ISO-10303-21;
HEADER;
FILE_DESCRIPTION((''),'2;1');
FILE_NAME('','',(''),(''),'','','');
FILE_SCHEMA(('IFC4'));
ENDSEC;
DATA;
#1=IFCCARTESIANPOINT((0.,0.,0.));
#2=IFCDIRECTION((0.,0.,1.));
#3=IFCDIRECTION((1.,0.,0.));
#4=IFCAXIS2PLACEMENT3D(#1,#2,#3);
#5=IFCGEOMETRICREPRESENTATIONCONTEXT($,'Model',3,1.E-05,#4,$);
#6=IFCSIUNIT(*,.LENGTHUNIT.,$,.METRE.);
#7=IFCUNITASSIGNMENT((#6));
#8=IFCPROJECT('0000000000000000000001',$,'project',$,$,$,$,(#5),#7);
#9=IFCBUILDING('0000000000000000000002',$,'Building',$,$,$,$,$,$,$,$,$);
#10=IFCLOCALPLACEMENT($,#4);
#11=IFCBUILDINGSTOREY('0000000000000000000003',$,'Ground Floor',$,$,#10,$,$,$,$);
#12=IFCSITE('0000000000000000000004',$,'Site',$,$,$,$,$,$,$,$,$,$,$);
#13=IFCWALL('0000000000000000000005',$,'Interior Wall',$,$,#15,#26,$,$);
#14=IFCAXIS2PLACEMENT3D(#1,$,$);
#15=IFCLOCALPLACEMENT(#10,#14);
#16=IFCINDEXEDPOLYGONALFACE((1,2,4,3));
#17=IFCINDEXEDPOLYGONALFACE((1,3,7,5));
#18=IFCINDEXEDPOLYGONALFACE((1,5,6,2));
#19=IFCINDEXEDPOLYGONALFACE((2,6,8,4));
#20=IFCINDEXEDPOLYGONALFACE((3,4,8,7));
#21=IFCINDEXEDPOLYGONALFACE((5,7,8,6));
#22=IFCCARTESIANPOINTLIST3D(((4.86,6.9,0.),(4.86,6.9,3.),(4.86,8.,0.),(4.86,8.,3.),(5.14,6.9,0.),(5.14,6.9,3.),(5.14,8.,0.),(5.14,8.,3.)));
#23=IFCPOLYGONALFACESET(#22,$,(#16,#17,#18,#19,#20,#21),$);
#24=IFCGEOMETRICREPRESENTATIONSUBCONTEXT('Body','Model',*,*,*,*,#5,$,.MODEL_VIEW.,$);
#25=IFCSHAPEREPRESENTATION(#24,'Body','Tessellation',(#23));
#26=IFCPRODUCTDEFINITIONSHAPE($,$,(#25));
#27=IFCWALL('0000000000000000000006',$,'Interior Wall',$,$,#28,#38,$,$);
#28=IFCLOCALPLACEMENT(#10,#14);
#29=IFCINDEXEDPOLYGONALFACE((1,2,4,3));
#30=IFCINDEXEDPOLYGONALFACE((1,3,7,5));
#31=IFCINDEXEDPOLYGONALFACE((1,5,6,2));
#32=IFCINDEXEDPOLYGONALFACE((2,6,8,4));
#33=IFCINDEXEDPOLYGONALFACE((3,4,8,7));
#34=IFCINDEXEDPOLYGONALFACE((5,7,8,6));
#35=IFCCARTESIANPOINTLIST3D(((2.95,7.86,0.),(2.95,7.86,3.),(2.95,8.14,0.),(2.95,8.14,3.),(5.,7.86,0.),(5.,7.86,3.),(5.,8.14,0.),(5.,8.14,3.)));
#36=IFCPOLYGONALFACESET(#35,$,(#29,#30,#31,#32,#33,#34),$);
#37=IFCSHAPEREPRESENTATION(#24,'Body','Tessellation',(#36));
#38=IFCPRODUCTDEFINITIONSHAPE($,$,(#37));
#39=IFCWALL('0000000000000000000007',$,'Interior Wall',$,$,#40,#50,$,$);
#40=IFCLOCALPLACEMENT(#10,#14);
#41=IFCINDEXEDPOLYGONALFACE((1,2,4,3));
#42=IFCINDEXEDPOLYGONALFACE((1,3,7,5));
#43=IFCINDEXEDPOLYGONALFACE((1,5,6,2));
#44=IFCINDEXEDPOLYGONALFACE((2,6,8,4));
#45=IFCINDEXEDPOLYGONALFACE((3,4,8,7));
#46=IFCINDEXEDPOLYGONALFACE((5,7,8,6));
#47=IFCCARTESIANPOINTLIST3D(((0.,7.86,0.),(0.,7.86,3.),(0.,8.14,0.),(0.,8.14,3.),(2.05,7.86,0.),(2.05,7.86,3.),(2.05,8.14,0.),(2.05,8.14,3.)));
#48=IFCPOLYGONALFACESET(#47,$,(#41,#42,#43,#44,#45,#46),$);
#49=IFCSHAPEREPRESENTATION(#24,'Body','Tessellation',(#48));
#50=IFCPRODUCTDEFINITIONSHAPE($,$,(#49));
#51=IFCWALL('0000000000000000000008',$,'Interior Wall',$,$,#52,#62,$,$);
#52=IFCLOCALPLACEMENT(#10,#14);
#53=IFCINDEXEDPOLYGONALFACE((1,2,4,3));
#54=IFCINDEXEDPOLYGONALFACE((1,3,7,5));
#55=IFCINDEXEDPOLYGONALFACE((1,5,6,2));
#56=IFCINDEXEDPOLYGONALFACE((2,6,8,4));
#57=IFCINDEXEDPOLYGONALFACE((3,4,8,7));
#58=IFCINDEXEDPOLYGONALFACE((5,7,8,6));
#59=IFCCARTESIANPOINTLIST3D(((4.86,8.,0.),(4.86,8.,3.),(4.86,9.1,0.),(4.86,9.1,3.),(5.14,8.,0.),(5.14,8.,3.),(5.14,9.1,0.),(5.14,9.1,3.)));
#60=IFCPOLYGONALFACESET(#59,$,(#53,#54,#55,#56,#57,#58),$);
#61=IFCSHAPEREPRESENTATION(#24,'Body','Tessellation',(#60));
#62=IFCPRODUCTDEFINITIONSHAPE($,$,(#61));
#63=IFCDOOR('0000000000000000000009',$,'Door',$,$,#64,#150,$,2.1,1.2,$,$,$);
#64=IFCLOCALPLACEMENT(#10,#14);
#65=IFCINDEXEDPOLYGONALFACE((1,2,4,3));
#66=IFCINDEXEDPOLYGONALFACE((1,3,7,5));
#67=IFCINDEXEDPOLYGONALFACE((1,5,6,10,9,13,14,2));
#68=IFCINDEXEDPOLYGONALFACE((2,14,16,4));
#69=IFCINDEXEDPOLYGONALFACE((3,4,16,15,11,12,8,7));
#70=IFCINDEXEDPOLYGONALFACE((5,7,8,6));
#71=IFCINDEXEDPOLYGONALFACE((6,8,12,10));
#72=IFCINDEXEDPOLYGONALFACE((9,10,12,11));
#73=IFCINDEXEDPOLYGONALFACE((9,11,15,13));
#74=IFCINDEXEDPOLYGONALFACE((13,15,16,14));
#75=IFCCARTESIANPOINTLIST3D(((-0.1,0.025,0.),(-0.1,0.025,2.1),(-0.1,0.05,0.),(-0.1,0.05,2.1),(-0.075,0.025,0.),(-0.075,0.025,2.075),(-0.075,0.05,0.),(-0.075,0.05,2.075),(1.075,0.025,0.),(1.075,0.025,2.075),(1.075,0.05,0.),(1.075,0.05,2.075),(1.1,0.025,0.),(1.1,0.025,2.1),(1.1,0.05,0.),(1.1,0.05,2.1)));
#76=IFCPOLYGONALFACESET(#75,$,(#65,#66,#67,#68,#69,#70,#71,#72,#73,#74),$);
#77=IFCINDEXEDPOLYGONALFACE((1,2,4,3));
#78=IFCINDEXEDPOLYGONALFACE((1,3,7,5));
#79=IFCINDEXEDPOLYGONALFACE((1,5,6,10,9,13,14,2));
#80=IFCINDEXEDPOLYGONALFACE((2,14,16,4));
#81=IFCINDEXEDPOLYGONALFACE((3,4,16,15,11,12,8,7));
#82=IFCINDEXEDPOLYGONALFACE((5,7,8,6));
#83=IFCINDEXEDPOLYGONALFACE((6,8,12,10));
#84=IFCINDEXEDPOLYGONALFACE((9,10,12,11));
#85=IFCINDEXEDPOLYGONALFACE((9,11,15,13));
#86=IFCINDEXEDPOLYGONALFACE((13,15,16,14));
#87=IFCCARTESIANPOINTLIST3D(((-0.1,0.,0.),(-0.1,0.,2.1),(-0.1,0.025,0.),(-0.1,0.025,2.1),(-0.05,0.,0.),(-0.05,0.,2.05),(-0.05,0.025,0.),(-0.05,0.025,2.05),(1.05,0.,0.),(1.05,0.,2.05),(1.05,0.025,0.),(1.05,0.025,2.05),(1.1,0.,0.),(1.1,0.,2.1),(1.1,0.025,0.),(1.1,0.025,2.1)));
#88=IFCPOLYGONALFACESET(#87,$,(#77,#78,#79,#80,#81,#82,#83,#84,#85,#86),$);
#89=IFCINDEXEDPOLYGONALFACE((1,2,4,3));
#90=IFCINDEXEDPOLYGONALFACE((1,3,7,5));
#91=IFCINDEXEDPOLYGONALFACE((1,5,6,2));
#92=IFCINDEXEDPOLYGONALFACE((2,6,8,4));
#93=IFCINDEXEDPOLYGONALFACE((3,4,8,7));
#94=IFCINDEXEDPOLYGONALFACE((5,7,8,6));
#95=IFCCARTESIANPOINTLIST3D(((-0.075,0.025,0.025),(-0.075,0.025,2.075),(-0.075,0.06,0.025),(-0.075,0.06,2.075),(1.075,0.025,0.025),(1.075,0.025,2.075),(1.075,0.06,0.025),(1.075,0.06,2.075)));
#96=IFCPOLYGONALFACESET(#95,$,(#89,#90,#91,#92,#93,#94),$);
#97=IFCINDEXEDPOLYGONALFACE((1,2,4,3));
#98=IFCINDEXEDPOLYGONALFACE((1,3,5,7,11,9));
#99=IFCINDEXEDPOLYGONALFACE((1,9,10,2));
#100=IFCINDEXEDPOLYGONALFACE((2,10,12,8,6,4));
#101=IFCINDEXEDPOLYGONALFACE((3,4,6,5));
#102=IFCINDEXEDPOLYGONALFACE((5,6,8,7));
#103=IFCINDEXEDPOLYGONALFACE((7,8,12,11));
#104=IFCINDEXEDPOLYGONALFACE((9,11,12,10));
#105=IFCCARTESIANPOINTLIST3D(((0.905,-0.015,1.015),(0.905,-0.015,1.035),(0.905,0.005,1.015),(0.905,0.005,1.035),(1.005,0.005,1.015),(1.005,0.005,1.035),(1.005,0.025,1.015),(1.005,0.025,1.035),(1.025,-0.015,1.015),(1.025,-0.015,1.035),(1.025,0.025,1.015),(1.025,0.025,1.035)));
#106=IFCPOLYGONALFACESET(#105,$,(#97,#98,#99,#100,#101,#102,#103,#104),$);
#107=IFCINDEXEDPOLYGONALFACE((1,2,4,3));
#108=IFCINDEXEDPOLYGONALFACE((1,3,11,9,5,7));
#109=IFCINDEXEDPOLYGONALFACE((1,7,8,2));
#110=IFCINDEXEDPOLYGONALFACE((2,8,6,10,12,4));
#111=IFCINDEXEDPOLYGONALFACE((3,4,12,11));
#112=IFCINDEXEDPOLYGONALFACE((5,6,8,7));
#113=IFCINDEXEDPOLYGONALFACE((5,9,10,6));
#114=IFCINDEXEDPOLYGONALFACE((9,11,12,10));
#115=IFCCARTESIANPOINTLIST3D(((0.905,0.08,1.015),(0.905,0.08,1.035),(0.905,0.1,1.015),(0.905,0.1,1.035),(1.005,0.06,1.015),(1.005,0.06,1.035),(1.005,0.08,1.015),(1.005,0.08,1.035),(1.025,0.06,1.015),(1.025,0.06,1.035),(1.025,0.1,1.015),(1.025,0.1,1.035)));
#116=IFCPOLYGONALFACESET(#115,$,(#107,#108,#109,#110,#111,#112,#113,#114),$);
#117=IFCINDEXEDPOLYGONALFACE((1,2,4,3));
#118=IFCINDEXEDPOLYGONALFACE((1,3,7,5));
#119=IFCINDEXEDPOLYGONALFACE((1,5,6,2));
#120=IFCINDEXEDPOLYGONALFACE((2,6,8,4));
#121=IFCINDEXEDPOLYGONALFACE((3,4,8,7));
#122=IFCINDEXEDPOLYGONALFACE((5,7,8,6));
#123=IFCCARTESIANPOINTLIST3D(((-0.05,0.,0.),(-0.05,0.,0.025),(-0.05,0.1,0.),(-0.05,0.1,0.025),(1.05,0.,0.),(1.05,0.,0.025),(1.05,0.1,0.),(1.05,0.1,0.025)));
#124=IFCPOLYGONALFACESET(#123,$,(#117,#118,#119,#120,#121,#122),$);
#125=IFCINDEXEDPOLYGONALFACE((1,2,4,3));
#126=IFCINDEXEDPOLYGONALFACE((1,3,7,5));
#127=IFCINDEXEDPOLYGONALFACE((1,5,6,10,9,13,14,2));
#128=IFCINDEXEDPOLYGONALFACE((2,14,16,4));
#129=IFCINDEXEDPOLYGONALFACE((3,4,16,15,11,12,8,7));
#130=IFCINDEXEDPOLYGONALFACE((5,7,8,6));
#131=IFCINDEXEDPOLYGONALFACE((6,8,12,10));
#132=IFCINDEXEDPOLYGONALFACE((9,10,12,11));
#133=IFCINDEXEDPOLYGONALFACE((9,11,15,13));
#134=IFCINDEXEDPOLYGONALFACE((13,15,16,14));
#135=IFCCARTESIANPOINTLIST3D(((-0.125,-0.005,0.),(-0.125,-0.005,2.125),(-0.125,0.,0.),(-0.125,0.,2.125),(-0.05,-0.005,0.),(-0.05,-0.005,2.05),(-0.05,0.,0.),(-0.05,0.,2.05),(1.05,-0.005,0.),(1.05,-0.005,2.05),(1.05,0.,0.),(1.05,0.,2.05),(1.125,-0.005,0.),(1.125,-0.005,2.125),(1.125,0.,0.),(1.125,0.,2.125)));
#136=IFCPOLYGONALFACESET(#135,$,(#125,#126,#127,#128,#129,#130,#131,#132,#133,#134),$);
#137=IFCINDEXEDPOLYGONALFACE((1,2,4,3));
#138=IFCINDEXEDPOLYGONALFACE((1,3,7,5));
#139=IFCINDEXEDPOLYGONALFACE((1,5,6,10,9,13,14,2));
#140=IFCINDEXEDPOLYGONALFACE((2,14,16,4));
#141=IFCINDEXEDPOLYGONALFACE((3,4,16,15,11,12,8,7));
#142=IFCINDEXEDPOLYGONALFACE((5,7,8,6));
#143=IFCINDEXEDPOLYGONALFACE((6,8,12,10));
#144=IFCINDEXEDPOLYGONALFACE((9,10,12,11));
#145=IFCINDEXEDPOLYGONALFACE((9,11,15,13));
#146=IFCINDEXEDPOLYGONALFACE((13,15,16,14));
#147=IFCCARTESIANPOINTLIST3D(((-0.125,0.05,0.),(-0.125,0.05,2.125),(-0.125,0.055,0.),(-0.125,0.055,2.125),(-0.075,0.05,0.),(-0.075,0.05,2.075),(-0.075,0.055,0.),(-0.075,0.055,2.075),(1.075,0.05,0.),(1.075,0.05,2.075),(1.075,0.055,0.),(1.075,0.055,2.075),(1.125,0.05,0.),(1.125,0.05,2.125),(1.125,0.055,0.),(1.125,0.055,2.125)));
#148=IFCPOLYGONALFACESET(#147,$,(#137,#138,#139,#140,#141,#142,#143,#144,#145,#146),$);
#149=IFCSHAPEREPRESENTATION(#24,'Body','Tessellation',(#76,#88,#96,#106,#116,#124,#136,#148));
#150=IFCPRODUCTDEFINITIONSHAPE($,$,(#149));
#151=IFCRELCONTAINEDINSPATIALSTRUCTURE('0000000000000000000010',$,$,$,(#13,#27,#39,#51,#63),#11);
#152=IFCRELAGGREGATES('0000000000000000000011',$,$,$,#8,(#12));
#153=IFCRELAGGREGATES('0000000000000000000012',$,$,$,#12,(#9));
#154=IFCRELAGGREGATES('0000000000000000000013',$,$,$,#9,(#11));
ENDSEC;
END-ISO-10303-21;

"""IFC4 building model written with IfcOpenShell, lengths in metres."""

from ifc_helpers import new_model, si_unit, frame, origin_with_axes, place, context, subcontext, project, spatial, line, indexed_curve, outline, extrude, element, save


model = new_model("IFC4")

# Units and contexts
model_context = context("Model", 3, precision=1e-05, world=origin_with_axes())
body_context = subcontext(model_context, "Body", "Model", "MODEL_VIEW")
ifc_project = project(units=[si_unit("LENGTHUNIT", "METRE")], contexts=[model_context])

# Site, building, storey
site = spatial("IfcSite", under=ifc_project, Name="Site")
building = spatial("IfcBuilding", under=site, Name="Building")
storey_placement = place(None, origin_with_axes())
storey = spatial("IfcBuildingStorey", under=building, at=storey_placement, Name="Ground Floor")

# Walls
for number, where, z_axis, x_axis, name in (
    (1, (5.0, 6.9, 0.0), (0.0, 0.0, 1.0), (0.0, 1.0, 0.0), "Interior Wall"),
):
    element("IfcWall", number, at=place(storey_placement, frame(where, z_axis=z_axis, x_axis=x_axis)), inside=storey, Name=name, context=body_context, shape_type="SweptSolid", body=[
        extrude(outline(indexed_curve([(0.0, 0.0), (0.0, 0.28), (1.1, 0.28), (1.1, 0.0), (0.0, 0.0)], self_intersect=False)), frame((0.0, -0.14, 0.0), z_axis=(0.0, 0.0, 1.0), x_axis=(1.0, 0.0, 0.0)), (0.0, 0.0, 1.0), 3.0),
    ])
for number, where, z_axis, x_axis, name in (
    (2, (5.0, 8.0, 0.0), (0.0, 0.0, 1.0), (-1.0, 0.0, 0.0), "Interior Wall"),
    (3, (2.05, 8.0, 0.0), (0.0, 0.0, 1.0), (-1.0, 0.0, 0.0), "Interior Wall"),
):
    element("IfcWall", number, at=place(storey_placement, frame(where, z_axis=z_axis, x_axis=x_axis)), inside=storey, Name=name, context=body_context, shape_type="SweptSolid", body=[
        extrude(outline(indexed_curve([(0.0, 0.0), (0.0, 0.28), (2.05, 0.28), (2.05, 0.0), (0.0, 0.0)], self_intersect=False)), frame((0.0, -0.14, 0.0), z_axis=(0.0, 0.0, 1.0), x_axis=(1.0, 0.0, 0.0)), (0.0, 0.0, 1.0), 3.0),
    ])
wall_1_placement = place(storey_placement, frame((5.0, 8.0, 0.0), z_axis=(0.0, 0.0, 1.0), x_axis=(0.0, 1.0, 0.0)))
element("IfcWall", 4, at=wall_1_placement, inside=storey, Name="Interior Wall", context=body_context, shape_type="SweptSolid", body=[
    extrude(outline(indexed_curve([(0.0, 0.0), (0.0, 0.28), (1.1, 0.28), (1.1, 0.0), (0.0, 0.0)], self_intersect=False)), frame((0.0, -0.14, 0.0), z_axis=(0.0, 0.0, 1.0), x_axis=(1.0, 0.0, 0.0)), (0.0, 0.0, 1.0), 3.0),
])

# Door
door_1_placement = place(storey_placement, frame((-0.1, 0.0, 0.0), z_axis=(0.0, 0.0, 1.0), x_axis=(1.0, 0.0, 0.0)))
element("IfcDoor", 5, at=door_1_placement, inside=storey, Name="Door", OverallHeight=2.1, OverallWidth=1.2, context=body_context, shape_type="SweptSolid", body=[
    extrude(outline(indexed_curve([(0.0, 0.0), (0.0, 2.1), (1.2, 2.1), (1.2, 0.0), (1.175, 0.0), (1.175, 2.075), (0.025, 2.075), (0.025, 0.0)], segments=[line(1, 2, 3, 4, 5, 6, 7, 8, 1)])), frame((0.0, 0.025, 0.0), z_axis=(0.0, -1.0, 0.0), x_axis=(1.0, 0.0, 0.0)), (0.0, 0.0, -1.0), 0.025),
    extrude(outline(indexed_curve([(0.0, 0.0), (0.0, 2.1), (1.2, 2.1), (1.2, 0.0), (1.15, 0.0), (1.15, 2.05), (0.05, 2.05), (0.05, 0.0)], segments=[line(1, 2, 3, 4, 5, 6, 7, 8, 1)])), frame((0.0, 0.0, 0.0), z_axis=(0.0, -1.0, 0.0), x_axis=(1.0, 0.0, 0.0)), (0.0, 0.0, -1.0), 0.025),
    extrude(outline(indexed_curve([(0.0, 0.0), (1.15, 0.0), (1.15, 0.035), (0.0, 0.035)], segments=[line(1, 2, 3, 4, 1)])), frame((0.025, 0.025, 0.025), z_axis=(0.0, 0.0, 1.0), x_axis=(1.0, 0.0, 0.0)), (0.0, 0.0, 1.0), 2.05),
    extrude(outline(indexed_curve([(0.0, 0.0), (0.0, -0.04), (-0.12, -0.04), (-0.12, -0.02), (-0.02, -0.02), (-0.02, 0.0)], segments=[line(1, 2, 3, 4, 5, 6, 1)])), frame((1.125, 0.025, 1.015), z_axis=(0.0, 0.0, 1.0), x_axis=(1.0, 0.0, 0.0)), (0.0, 0.0, 1.0), 0.02),
    extrude(outline(indexed_curve([(0.0, 0.0), (0.0, 0.04), (-0.12, 0.04), (-0.12, 0.02), (-0.02, 0.02), (-0.02, 0.0)], segments=[line(1, 2, 3, 4, 5, 6, 1)])), frame((1.125, 0.06, 1.015), z_axis=(0.0, 0.0, 1.0), x_axis=(1.0, 0.0, 0.0)), (0.0, 0.0, 1.0), 0.02),
    extrude(outline(indexed_curve([(0.0, 0.0), (1.1, 0.0), (1.1, 0.1), (0.0, 0.1)], segments=[line(1, 2, 3, 4, 1)])), frame((0.05, 0.0, 0.0), z_axis=(0.0, 0.0, 1.0), x_axis=(1.0, 0.0, 0.0)), (0.0, 0.0, 1.0), 0.025),
    extrude(outline(indexed_curve([(0.0, 0.0), (0.0, 2.125), (1.25, 2.125), (1.25, 0.0), (1.175, 0.0), (1.175, 2.05), (0.075, 2.05), (0.075, 0.0)], segments=[line(1, 2, 3, 4, 5, 6, 7, 8, 1)])), frame((-0.025, -0.005, 0.0), z_axis=(0.0, -1.0, 0.0), x_axis=(1.0, 0.0, 0.0)), (0.0, 0.0, -1.0), 0.005),
    extrude(outline(indexed_curve([(0.0, 0.0), (0.0, 2.125), (1.25, 2.125), (1.25, 0.0), (1.2, 0.0), (1.2, 2.075), (0.05, 2.075), (0.05, 0.0)], segments=[line(1, 2, 3, 4, 5, 6, 7, 8, 1)])), frame((-0.025, 0.05, 0.0), z_axis=(0.0, -1.0, 0.0), x_axis=(1.0, 0.0, 0.0)), (0.0, 0.0, -1.0), 0.005),
])

save(model, "model.ifc")
